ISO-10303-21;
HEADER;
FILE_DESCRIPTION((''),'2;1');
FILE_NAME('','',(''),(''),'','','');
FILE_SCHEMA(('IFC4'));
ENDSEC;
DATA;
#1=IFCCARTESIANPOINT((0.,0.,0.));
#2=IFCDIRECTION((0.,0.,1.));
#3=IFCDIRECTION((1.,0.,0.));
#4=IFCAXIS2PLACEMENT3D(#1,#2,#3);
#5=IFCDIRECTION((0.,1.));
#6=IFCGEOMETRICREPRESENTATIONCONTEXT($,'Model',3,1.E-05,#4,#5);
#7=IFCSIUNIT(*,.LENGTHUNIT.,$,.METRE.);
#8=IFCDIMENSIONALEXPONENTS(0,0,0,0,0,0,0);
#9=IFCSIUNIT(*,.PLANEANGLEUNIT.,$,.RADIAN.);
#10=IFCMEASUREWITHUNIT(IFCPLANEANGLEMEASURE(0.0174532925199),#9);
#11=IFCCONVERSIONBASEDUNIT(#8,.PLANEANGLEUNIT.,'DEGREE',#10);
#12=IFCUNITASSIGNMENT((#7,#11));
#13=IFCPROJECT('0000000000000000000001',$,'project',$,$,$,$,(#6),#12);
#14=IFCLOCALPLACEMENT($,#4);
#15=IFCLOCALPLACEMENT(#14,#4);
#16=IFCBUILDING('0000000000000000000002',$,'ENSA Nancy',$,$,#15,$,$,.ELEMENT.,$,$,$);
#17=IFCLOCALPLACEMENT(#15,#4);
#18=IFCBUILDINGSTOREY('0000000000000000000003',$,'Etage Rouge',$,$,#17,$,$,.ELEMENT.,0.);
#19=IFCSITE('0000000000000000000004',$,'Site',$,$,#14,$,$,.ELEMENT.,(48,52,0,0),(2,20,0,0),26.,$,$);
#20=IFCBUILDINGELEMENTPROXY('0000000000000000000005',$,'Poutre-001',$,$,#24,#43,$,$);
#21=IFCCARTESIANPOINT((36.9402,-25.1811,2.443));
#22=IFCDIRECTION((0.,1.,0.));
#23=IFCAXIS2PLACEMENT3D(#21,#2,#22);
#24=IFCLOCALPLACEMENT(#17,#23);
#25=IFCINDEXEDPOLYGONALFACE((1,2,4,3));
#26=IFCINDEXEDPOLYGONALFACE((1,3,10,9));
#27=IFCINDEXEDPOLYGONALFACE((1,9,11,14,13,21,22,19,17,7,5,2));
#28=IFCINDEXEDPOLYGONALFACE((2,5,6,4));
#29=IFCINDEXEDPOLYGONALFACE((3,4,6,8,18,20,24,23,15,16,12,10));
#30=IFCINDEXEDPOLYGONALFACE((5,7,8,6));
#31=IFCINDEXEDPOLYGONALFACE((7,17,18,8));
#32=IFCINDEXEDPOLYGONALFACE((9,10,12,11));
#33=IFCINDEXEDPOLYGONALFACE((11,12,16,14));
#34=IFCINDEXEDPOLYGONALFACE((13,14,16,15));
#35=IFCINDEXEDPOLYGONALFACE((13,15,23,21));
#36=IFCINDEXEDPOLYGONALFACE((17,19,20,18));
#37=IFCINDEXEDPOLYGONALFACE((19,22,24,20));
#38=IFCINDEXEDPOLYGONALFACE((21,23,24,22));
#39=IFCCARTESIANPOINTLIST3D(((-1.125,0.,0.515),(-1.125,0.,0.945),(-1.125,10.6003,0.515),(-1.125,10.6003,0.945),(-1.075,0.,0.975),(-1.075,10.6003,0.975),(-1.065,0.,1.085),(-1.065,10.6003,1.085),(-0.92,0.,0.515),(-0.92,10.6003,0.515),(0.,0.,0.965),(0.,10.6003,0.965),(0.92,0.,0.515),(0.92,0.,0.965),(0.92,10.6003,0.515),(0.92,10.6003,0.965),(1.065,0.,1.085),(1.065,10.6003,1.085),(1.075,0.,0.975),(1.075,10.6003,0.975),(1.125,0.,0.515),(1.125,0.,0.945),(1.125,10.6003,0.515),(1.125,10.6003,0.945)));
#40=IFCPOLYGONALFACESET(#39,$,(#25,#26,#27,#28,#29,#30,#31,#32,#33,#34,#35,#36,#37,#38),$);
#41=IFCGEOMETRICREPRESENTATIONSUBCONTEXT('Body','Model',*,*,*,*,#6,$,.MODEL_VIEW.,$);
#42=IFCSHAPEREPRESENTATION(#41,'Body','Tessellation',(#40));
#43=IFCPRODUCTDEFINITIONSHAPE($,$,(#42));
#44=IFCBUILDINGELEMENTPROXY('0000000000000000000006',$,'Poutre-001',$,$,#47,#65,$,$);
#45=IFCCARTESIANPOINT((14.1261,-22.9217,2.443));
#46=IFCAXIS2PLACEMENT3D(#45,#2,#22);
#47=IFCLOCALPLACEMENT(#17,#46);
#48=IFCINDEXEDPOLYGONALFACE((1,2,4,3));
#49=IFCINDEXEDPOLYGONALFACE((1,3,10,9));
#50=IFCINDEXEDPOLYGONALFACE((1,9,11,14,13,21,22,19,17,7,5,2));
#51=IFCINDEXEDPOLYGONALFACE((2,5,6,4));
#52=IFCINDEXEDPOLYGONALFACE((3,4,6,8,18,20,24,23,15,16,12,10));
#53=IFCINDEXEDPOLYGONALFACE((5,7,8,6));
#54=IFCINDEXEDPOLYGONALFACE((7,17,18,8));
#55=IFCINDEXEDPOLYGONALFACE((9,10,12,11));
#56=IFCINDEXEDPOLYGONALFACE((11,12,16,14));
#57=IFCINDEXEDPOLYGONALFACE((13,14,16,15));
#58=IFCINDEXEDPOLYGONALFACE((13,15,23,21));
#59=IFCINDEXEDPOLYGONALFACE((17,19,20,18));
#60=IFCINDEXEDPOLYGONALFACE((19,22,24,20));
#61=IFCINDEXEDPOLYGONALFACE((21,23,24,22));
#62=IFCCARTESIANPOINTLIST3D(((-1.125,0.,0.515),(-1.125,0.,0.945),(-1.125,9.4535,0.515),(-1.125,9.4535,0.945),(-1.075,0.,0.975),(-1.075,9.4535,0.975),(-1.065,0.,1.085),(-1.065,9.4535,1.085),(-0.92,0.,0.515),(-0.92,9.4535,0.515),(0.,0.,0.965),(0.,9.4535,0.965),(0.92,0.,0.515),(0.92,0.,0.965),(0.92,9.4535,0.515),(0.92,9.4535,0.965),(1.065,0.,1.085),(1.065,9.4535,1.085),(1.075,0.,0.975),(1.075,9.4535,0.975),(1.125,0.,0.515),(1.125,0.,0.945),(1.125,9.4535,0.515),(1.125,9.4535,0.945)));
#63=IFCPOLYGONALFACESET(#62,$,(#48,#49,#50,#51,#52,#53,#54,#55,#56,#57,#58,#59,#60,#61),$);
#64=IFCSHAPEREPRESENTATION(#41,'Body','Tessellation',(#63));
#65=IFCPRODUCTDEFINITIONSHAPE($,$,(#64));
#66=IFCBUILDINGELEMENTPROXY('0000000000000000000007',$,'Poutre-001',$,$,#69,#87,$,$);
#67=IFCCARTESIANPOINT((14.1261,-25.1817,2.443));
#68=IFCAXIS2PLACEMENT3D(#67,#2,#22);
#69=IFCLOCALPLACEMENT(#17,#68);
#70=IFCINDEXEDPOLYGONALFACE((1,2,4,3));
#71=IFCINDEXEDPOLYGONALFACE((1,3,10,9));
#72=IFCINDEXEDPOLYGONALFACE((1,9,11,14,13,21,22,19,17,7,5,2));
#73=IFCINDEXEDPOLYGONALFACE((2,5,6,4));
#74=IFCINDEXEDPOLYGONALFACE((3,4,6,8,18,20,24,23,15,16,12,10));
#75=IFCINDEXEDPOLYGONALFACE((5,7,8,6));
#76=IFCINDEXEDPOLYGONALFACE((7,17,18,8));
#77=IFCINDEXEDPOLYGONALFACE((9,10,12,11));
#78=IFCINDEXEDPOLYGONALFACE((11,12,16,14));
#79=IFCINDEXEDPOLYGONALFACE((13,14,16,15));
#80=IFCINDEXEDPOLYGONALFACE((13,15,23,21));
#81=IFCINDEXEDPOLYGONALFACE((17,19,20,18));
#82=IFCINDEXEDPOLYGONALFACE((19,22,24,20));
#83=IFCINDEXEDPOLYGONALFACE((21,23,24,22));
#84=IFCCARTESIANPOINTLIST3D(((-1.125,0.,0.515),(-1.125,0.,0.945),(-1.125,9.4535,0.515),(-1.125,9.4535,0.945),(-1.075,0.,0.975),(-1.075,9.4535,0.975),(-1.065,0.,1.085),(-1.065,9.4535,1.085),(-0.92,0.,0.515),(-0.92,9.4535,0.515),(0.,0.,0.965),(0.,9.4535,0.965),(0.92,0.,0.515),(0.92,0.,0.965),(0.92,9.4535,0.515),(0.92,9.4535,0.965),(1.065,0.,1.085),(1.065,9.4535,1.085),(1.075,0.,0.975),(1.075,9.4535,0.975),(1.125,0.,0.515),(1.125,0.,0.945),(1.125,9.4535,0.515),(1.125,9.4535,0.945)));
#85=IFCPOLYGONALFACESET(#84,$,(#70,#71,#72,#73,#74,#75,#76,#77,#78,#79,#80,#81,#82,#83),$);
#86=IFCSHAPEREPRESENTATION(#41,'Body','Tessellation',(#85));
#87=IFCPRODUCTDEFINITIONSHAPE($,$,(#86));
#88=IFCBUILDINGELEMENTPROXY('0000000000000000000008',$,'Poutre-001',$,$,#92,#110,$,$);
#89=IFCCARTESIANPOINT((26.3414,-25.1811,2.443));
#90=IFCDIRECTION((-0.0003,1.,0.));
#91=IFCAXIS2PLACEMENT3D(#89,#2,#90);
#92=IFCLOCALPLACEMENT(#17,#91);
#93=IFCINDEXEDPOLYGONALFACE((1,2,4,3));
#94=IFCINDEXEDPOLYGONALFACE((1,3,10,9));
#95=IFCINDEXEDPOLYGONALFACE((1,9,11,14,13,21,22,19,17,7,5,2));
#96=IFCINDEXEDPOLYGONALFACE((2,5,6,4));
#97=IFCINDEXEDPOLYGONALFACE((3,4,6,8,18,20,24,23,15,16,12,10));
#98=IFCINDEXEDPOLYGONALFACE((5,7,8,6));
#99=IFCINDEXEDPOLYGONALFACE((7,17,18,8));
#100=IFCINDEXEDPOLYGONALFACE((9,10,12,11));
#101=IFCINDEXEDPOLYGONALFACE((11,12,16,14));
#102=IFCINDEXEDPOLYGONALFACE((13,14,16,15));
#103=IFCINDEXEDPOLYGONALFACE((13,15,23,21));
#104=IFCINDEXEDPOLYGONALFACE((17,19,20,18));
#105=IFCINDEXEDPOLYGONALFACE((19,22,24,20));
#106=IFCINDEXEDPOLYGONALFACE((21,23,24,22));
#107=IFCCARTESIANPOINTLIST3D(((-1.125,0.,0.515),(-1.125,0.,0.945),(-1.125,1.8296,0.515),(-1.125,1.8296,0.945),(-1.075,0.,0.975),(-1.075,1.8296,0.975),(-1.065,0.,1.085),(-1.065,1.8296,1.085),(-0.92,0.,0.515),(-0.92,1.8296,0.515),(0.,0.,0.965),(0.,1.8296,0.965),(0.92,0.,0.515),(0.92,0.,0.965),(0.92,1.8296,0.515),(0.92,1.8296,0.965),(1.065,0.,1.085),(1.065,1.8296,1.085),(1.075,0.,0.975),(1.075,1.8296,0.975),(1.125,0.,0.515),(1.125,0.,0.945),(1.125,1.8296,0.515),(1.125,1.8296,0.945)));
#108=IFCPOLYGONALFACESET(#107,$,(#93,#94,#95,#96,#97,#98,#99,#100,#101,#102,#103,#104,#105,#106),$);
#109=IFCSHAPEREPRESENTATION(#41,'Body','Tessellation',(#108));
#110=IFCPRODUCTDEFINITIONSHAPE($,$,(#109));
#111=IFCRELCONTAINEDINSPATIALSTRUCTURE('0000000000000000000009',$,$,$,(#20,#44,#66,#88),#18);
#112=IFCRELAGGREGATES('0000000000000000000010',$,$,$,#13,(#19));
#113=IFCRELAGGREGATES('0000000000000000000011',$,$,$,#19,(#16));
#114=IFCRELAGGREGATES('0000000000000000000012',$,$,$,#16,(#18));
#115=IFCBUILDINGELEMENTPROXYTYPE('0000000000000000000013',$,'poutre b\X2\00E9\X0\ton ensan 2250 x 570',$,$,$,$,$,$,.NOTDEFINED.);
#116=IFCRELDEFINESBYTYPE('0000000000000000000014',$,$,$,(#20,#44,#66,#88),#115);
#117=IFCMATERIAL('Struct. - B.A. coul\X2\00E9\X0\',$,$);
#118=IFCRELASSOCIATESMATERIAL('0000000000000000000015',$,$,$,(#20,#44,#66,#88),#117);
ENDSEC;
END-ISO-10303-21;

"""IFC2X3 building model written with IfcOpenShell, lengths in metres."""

from ifc_helpers import new_model, entity, si_unit, converted_unit, direction, frame, origin_with_axes, place, context, subcontext, project, spatial, polyline, outline, extrude, material, type_object, element, save


model = new_model("IFC2X3")

# Units and contexts
model_context = context("Model", 3, precision=1e-05, world=origin_with_axes(), true_north=direction((0.0, 1.0)))
body_context = subcontext(model_context, "Body", "Model", "MODEL_VIEW")
ifc_project = project(units=[si_unit("LENGTHUNIT", "METRE"), converted_unit("PLANEANGLEUNIT", "DEGREE", entity("IfcPlaneAngleMeasure", 0.0174532925199), si_unit("PLANEANGLEUNIT", "RADIAN"), dimensions=[0, 0, 0, 0, 0, 0, 0])], contexts=[model_context])

# Site, building, storey
site_placement = place(None, origin_with_axes())
site = spatial("IfcSite", under=ifc_project, at=site_placement, Name="Site", CompositionType="ELEMENT", RefLatitude=(48, 52, 0, 0), RefLongitude=(2, 20, 0, 0), RefElevation=26.0)
building_placement = place(site_placement, origin_with_axes())
building = spatial("IfcBuilding", under=site, at=building_placement, Name="ENSA Nancy", CompositionType="ELEMENT")
storey_placement = place(building_placement, origin_with_axes())
storey = spatial("IfcBuildingStorey", under=building, at=storey_placement, Name="Etage Rouge", CompositionType="ELEMENT", Elevation=0.0)

# Building element proxies
ifc_material_1 = material(Name="Struct. - B.A. coulé")
building_element_proxy_type_1 = type_object("IfcBuildingElementProxyType", Name="poutre béton ensan 2250 x 570", PredefinedType="NOTDEFINED")
proxy_1_placement = place(storey_placement, frame((36.9402, -25.1811, 2.443), z_axis=(0.0, 0.0, 1.0), x_axis=(0.0, 1.0, 0.0)))
element("IfcBuildingElementProxy", 1, at=proxy_1_placement, inside=storey, type_object=building_element_proxy_type_1, material=ifc_material_1, Name="Poutre-001", context=body_context, shape_type="SweptSolid", body=[
    extrude(outline(polyline([(-1.065, 1.085), (-1.075, 0.975), (-1.125, 0.945), (-1.125, 0.515), (-0.92, 0.515), (0.0, 0.965), (0.92, 0.965), (0.92, 0.515), (1.125, 0.515), (1.125, 0.945), (1.075, 0.975), (1.065, 1.085), (-1.065, 1.085)])), frame((0.0, 10.6003, 0.0), z_axis=(0.0, -1.0, 0.0), x_axis=(1.0, 0.0, 0.0)), (0.0, 0.0, 1.0), 10.6003),
])
for number, where, z_axis, x_axis, name in (
    (2, (14.1261, -22.9217, 2.443), (0.0, 0.0, 1.0), (0.0, 1.0, 0.0), "Poutre-001"),
    (3, (14.1261, -25.1817, 2.443), (0.0, 0.0, 1.0), (0.0, 1.0, 0.0), "Poutre-001"),
):
    element("IfcBuildingElementProxy", number, at=place(storey_placement, frame(where, z_axis=z_axis, x_axis=x_axis)), inside=storey, type_object=building_element_proxy_type_1, material=ifc_material_1, Name=name, context=body_context, shape_type="SweptSolid", body=[
        extrude(outline(polyline([(-1.065, 1.085), (-1.075, 0.975), (-1.125, 0.945), (-1.125, 0.515), (-0.92, 0.515), (0.0, 0.965), (0.92, 0.965), (0.92, 0.515), (1.125, 0.515), (1.125, 0.945), (1.075, 0.975), (1.065, 1.085), (-1.065, 1.085)])), frame((0.0, 9.4535, 0.0), z_axis=(0.0, -1.0, 0.0), x_axis=(1.0, 0.0, 0.0)), (0.0, 0.0, 1.0), 9.4535),
    ])
proxy_2_placement = place(storey_placement, frame((26.3414, -25.1811, 2.443), z_axis=(0.0, 0.0, 1.0), x_axis=(-0.0003, 1.0, 0.0)))
element("IfcBuildingElementProxy", 4, at=proxy_2_placement, inside=storey, type_object=building_element_proxy_type_1, material=ifc_material_1, Name="Poutre-001", context=body_context, shape_type="SweptSolid", body=[
    extrude(outline(polyline([(-1.065, 1.085), (-1.075, 0.975), (-1.125, 0.945), (-1.125, 0.515), (-0.92, 0.515), (0.0, 0.965), (0.92, 0.965), (0.92, 0.515), (1.125, 0.515), (1.125, 0.945), (1.075, 0.975), (1.065, 1.085), (-1.065, 1.085)])), frame((0.0, 1.8296, 0.0), z_axis=(0.0, -1.0, 0.0), x_axis=(1.0, 0.0, 0.0)), (0.0, 0.0, 1.0), 1.8296),
])

save(model, "model.ifc")
